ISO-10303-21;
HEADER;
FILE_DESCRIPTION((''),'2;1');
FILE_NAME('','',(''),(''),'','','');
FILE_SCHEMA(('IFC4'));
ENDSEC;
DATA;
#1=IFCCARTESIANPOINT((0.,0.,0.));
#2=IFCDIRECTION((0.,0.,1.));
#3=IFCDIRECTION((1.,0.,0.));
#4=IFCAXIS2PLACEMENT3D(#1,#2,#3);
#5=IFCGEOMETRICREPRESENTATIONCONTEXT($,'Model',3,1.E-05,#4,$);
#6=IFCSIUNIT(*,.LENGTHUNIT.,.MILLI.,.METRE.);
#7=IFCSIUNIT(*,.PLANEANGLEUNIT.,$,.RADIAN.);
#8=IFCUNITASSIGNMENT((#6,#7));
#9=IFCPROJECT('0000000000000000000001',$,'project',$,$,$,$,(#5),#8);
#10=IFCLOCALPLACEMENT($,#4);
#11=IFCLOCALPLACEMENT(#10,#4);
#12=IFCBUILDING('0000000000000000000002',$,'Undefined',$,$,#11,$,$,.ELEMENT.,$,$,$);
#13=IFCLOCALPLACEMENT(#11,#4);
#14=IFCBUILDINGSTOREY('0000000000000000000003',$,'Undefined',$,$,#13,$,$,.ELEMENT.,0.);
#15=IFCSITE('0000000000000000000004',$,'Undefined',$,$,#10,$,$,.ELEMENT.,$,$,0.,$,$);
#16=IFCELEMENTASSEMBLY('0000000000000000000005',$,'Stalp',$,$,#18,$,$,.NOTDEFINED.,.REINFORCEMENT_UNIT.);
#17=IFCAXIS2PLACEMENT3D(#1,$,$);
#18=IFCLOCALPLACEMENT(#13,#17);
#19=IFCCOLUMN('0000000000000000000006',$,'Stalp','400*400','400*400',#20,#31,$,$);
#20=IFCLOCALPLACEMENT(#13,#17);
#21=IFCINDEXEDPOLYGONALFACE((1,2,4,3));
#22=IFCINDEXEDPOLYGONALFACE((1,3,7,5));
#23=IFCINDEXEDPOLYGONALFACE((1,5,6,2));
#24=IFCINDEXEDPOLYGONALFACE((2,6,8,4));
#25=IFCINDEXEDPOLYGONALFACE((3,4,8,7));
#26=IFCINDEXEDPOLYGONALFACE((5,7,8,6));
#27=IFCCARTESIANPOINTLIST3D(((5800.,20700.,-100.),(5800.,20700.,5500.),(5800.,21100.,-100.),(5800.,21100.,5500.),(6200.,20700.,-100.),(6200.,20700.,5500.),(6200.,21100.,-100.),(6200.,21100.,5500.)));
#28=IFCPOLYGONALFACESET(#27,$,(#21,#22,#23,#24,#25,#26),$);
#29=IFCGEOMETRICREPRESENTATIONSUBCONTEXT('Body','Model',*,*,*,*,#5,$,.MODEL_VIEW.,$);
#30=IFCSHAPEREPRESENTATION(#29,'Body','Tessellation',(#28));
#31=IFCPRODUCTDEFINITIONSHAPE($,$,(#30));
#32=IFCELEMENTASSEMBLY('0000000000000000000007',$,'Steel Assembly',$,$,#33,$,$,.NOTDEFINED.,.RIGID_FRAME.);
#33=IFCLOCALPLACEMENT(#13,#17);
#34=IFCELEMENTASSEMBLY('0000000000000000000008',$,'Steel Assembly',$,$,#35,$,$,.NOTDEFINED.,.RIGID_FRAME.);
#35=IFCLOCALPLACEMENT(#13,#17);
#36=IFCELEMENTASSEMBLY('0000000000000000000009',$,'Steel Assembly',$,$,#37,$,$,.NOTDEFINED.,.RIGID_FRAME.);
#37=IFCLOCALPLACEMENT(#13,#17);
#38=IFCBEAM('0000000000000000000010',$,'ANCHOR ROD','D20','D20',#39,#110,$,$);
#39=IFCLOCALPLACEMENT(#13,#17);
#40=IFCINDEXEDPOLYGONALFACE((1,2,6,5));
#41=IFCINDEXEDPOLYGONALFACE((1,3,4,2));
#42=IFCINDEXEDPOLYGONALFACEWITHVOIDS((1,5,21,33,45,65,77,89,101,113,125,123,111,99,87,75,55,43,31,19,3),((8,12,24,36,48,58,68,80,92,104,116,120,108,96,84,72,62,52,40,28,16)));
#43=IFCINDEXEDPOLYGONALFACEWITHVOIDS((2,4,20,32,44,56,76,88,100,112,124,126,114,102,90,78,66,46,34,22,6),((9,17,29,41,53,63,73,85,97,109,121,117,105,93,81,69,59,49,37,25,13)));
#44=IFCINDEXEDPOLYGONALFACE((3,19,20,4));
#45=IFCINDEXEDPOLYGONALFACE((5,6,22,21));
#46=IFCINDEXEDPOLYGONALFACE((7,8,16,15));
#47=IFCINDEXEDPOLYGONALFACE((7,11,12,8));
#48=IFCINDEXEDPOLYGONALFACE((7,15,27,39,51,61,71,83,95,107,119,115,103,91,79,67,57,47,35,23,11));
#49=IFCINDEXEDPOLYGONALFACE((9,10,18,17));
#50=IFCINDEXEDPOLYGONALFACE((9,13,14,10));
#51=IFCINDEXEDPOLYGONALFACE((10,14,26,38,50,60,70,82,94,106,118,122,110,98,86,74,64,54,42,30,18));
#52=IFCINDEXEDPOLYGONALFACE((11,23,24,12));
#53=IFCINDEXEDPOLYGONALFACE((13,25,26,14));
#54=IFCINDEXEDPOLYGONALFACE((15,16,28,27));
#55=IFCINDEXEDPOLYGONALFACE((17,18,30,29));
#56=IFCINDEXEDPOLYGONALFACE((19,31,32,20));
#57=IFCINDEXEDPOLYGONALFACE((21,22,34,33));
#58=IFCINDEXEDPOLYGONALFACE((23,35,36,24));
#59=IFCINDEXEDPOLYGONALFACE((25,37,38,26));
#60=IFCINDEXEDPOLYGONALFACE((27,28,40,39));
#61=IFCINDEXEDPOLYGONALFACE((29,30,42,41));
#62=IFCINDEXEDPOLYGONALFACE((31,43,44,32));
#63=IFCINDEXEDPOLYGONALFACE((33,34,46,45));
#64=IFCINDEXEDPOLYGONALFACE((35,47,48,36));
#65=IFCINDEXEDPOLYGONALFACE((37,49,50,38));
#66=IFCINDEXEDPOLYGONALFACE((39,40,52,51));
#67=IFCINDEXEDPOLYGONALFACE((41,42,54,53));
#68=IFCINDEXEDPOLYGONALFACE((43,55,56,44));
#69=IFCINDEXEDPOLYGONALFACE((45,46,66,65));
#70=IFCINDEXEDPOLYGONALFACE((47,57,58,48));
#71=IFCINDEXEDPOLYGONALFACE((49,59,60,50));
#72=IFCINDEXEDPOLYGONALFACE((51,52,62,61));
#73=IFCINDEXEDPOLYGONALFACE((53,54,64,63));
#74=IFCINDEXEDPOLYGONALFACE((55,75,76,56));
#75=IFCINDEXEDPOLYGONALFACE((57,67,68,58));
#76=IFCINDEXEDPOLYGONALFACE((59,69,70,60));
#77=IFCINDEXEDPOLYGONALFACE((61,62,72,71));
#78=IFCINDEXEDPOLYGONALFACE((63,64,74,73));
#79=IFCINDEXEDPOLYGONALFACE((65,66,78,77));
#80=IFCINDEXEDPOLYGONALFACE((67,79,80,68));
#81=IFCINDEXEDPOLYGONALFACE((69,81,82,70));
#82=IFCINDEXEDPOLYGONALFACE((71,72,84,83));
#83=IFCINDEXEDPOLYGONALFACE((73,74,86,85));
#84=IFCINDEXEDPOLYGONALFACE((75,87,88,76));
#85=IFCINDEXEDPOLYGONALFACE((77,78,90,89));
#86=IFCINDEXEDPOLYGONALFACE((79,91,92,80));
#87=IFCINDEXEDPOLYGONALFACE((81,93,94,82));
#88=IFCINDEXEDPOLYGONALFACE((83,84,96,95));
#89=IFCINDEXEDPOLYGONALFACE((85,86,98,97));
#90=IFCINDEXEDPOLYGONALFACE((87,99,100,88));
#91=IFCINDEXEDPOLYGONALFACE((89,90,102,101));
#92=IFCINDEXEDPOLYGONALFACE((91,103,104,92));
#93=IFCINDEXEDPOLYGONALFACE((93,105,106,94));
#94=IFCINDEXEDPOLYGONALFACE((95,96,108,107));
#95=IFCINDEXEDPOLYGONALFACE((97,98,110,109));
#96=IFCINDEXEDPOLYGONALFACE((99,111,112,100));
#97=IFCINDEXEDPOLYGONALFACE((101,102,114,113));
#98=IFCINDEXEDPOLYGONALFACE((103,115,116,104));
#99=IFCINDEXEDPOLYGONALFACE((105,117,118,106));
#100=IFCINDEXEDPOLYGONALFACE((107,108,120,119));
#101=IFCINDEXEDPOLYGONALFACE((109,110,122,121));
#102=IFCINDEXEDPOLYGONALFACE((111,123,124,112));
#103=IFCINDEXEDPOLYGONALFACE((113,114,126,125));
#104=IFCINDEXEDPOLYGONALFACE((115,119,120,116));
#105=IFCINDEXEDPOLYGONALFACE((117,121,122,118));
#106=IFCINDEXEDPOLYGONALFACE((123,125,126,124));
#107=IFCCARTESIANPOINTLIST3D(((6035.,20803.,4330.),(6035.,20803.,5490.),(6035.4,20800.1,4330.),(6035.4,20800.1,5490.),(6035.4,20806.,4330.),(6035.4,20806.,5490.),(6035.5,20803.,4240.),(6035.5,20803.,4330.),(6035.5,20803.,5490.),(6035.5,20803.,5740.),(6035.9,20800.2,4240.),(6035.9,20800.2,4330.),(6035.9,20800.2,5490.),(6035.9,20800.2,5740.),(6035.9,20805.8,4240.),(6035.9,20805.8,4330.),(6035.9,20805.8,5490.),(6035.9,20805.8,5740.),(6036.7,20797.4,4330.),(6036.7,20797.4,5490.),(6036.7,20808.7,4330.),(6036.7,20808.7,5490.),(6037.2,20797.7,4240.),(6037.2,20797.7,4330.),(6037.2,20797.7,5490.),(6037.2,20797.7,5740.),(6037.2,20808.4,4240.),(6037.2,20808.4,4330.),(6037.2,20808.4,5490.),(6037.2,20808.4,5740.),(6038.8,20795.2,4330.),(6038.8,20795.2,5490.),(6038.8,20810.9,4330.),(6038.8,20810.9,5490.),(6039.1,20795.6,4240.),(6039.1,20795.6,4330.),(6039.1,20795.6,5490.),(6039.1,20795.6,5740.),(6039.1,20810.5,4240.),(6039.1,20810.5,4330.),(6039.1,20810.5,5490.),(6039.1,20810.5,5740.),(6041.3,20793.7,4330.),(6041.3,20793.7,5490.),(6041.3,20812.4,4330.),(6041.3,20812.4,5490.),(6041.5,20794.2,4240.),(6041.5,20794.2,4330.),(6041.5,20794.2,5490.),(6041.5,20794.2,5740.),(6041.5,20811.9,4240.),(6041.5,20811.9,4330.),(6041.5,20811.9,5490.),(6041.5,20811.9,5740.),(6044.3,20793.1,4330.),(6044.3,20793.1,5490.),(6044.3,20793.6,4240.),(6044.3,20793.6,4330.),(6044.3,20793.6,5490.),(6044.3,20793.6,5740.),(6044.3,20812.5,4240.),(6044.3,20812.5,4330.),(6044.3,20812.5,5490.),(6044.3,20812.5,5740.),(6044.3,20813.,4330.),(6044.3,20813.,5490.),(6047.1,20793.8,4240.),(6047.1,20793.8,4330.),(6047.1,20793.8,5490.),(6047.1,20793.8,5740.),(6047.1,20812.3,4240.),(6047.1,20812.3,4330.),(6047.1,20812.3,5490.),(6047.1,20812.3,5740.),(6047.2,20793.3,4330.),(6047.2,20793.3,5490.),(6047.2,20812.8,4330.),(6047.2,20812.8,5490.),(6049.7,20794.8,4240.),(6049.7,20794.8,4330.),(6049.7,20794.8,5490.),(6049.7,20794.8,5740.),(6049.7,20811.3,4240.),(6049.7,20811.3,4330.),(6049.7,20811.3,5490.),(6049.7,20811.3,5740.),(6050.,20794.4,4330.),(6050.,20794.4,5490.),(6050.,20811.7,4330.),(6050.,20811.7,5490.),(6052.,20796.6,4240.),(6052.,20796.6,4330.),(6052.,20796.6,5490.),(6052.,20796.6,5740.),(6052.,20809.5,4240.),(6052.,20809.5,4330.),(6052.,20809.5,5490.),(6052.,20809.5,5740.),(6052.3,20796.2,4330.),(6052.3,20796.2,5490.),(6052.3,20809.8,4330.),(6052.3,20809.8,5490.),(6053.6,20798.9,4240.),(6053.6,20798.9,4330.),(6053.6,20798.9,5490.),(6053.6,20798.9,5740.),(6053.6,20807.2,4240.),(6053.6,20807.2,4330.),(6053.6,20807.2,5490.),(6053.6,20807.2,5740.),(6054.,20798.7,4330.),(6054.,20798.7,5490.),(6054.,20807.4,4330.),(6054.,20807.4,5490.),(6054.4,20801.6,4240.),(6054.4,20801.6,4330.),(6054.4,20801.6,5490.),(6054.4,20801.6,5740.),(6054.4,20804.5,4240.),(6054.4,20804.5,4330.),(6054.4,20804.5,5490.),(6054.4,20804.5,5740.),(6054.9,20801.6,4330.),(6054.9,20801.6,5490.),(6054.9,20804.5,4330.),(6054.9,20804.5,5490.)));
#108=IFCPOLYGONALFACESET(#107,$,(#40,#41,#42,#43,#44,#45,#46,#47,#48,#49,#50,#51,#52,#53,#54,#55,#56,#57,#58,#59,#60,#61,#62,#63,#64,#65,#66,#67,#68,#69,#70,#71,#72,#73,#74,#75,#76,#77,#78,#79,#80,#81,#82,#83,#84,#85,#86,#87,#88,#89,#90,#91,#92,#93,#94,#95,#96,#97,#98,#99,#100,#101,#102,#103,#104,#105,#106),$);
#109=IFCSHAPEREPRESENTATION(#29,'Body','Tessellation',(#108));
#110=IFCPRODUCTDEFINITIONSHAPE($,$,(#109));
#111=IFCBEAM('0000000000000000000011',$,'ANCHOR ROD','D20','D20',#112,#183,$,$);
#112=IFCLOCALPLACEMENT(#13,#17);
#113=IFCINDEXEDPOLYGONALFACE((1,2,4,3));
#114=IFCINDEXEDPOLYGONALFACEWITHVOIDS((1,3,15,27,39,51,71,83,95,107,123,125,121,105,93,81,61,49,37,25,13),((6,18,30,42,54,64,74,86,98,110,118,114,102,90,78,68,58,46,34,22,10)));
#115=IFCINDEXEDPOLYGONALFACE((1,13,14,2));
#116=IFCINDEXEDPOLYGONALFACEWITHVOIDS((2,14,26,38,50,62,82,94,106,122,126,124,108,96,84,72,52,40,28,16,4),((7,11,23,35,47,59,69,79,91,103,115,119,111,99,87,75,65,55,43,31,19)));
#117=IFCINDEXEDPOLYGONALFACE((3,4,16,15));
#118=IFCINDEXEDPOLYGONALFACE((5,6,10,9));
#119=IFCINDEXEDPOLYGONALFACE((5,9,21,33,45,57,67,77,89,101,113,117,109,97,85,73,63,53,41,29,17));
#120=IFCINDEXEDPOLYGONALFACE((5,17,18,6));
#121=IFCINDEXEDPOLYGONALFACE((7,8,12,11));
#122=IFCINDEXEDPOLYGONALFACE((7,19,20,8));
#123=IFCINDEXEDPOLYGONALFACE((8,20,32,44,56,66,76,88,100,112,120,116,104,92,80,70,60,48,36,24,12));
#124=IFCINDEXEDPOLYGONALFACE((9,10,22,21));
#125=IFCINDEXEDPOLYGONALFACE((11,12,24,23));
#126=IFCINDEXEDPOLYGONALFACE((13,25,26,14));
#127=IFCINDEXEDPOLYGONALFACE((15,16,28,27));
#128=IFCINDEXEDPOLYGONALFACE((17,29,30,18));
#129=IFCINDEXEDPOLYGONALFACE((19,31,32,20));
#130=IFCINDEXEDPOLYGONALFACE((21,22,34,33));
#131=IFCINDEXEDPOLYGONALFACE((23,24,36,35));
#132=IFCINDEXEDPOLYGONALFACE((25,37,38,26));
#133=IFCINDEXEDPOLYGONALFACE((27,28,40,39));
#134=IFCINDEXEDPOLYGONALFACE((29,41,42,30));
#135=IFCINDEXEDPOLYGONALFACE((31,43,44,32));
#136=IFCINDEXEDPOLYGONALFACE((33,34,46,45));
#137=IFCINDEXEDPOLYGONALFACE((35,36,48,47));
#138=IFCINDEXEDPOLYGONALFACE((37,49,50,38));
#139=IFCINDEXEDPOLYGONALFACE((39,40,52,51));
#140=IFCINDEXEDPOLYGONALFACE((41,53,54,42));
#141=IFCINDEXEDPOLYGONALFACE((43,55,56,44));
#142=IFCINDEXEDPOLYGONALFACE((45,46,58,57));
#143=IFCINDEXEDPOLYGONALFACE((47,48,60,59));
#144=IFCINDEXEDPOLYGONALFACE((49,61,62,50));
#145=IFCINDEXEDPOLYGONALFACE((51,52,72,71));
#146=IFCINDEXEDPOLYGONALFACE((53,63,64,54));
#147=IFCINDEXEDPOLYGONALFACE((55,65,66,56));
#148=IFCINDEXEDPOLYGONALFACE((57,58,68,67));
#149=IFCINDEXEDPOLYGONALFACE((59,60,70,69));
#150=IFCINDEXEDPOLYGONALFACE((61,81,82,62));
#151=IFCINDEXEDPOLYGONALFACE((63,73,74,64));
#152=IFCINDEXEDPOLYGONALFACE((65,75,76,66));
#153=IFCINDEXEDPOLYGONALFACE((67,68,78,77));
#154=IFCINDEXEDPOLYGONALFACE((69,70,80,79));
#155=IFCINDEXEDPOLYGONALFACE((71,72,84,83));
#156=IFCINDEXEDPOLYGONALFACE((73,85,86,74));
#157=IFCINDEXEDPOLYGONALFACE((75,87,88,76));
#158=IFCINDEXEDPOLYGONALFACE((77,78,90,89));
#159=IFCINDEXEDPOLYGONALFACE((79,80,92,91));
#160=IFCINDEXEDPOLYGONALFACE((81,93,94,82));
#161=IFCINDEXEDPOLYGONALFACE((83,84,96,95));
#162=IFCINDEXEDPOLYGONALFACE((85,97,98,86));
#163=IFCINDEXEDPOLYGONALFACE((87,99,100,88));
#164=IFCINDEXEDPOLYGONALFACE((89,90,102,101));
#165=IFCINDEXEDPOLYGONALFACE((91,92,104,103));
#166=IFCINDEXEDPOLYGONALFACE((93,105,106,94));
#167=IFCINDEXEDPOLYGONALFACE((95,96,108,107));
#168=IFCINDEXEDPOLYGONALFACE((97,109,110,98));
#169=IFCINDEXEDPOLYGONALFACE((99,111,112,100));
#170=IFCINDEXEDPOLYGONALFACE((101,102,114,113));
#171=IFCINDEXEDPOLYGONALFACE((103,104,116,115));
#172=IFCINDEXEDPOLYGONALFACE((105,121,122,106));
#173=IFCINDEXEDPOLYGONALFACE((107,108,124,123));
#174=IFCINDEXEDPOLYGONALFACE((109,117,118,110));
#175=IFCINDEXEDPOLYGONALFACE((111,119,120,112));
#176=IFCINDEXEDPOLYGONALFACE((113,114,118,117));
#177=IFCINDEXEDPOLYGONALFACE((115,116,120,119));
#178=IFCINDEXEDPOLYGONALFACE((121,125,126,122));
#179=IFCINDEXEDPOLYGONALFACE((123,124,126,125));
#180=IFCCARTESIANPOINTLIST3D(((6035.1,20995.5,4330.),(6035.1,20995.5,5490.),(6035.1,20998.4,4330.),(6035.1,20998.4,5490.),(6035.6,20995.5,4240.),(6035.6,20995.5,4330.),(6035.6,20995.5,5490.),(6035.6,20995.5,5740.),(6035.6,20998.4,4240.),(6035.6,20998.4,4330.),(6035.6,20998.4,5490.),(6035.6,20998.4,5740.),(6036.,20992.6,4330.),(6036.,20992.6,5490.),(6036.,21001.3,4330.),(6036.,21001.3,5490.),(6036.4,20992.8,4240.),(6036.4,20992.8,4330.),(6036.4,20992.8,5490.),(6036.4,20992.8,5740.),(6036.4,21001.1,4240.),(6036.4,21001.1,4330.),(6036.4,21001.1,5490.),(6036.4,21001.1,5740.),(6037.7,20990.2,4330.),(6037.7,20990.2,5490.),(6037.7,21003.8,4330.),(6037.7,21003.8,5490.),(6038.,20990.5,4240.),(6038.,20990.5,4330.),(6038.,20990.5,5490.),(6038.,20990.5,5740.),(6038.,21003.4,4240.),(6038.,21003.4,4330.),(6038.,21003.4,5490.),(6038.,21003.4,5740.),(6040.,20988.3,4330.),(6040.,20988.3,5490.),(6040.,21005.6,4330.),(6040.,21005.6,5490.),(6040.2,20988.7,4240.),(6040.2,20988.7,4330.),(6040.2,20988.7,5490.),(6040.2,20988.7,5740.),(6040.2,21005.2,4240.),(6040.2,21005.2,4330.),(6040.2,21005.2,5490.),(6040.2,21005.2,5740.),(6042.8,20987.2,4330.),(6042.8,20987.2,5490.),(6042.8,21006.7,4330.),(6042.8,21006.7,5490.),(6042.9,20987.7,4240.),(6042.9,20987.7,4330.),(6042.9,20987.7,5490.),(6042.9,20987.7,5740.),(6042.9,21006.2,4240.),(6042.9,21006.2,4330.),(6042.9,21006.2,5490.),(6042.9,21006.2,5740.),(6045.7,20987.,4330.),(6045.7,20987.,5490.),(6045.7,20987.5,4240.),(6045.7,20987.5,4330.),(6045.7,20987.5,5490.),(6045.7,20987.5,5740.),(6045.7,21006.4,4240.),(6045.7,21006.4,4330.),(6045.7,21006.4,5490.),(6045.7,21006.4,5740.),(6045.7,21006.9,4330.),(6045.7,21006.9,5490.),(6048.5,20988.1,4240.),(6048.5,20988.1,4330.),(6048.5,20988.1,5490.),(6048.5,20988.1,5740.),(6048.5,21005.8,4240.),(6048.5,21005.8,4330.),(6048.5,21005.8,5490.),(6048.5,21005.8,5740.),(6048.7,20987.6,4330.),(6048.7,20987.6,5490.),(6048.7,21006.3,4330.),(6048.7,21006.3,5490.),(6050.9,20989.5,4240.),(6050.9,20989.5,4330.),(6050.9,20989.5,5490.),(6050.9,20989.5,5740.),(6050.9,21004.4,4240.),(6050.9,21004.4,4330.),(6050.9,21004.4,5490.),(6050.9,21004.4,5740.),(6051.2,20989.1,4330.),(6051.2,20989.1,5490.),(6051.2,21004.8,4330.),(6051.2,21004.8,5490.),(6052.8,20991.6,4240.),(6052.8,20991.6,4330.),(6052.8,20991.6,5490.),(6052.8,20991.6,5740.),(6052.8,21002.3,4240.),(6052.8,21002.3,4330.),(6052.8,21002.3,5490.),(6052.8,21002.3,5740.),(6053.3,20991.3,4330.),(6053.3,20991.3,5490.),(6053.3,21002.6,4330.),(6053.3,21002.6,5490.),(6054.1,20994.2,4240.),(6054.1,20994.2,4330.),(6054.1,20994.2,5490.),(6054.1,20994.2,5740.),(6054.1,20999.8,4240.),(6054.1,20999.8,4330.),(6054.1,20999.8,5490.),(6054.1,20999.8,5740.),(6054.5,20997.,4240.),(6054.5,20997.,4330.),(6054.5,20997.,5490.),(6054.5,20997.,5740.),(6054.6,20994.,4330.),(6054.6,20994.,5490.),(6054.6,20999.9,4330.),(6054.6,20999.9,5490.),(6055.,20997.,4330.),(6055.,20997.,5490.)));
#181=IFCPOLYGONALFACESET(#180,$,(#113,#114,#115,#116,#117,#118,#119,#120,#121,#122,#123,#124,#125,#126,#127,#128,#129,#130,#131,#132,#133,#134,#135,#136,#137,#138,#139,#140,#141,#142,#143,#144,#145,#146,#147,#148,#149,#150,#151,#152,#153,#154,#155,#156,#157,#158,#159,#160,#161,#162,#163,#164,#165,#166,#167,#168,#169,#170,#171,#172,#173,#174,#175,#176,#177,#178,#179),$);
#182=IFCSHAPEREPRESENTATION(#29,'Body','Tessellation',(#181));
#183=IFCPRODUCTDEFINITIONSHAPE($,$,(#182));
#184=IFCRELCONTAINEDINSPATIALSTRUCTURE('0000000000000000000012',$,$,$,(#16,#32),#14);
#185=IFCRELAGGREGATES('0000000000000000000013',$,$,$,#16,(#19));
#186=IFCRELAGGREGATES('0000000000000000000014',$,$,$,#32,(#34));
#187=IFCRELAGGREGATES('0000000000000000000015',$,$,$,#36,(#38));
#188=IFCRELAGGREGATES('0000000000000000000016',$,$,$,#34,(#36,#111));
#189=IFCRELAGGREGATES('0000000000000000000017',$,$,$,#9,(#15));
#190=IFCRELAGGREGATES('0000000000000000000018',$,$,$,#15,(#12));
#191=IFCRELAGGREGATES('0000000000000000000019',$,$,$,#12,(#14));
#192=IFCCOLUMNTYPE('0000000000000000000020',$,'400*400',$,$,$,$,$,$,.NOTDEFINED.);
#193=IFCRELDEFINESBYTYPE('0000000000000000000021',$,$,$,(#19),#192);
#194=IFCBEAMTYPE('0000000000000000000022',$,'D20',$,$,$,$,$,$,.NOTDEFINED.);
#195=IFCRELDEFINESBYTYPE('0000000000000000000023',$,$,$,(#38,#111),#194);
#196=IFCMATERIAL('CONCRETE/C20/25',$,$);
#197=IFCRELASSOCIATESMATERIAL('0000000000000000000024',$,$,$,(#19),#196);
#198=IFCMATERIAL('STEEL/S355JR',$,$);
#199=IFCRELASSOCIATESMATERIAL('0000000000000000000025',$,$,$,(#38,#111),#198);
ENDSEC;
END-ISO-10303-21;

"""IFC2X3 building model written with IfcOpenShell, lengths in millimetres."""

from ifc_helpers import new_model, si_unit, frame, origin_with_axes, origin_2d_with_axis, place, context, subcontext, project, spatial, rectangle, circle, extrude, boolean, material, type_object, element, aggregate, save


model = new_model("IFC2X3")

# Units and contexts
model_context = context("Model", 3, precision=1e-05, world=origin_with_axes())
body_context = subcontext(model_context, "Body", "Model", "MODEL_VIEW")
ifc_project = project(units=[si_unit("LENGTHUNIT", "METRE", prefix="MILLI"), si_unit("PLANEANGLEUNIT", "RADIAN")], contexts=[model_context])

# Site, building, storey
site_placement = place(None, origin_with_axes())
site = spatial("IfcSite", under=ifc_project, at=site_placement, Name="Undefined", CompositionType="ELEMENT", RefElevation=0.0)
building_placement = place(site_placement, origin_with_axes())
building = spatial("IfcBuilding", under=site, at=building_placement, Name="Undefined", CompositionType="ELEMENT")
storey_placement = place(building_placement, origin_with_axes())
storey = spatial("IfcBuildingStorey", under=building, at=storey_placement, Name="Undefined", CompositionType="ELEMENT", Elevation=0.0)

# Element assembly, column
assembly_1_placement = place(storey_placement, origin_with_axes())
assembly_1 = element("IfcElementAssembly", 1, at=assembly_1_placement, inside=storey, Name="Stalp", AssemblyPlace="NOTDEFINED", PredefinedType="REINFORCEMENT_UNIT")
ifc_material_1 = material(Name="CONCRETE/C20/25")
column_type = type_object("IfcColumnType", Name="400*400", PredefinedType="NOTDEFINED")
column_placement = place(assembly_1_placement, frame((6000.0, 20900.0, -100.0), z_axis=(0.0, 0.0, 1.0), x_axis=(0.0, 1.0, 0.0)))
column = element("IfcColumn", 2, at=column_placement, type_object=column_type, material=ifc_material_1, Name="Stalp", Description="400*400", ObjectType="400*400", context=body_context, shape_type="SweptSolid", body=[
    extrude(rectangle(XDim=400.0, YDim=400.0, at=origin_2d_with_axis()), frame((0.0, 0.0, 5600.0), z_axis=(0.0, 0.0, -1.0), x_axis=(0.0, 1.0, 0.0)), (0.0, 0.0, 1.0), 5600.0),
])
aggregate(assembly_1, [column])

# Element assemblies, beams
assembly_2_placement = place(storey_placement, origin_with_axes())
assembly_2 = element("IfcElementAssembly", 3, at=assembly_2_placement, inside=storey, Name="Steel Assembly", AssemblyPlace="NOTDEFINED", PredefinedType="RIGID_FRAME")
assembly_3_placement = place(assembly_2_placement, origin_with_axes())
assembly_3 = element("IfcElementAssembly", 4, at=assembly_3_placement, Name="Steel Assembly", AssemblyPlace="NOTDEFINED", PredefinedType="RIGID_FRAME")
assembly_4_placement = place(assembly_3_placement, origin_with_axes())
assembly_4 = element("IfcElementAssembly", 5, at=assembly_4_placement, Name="Steel Assembly", AssemblyPlace="NOTDEFINED", PredefinedType="RIGID_FRAME")
ifc_material_2 = material(Name="STEEL/S355JR")
beam_type = type_object("IfcBeamType", Name="D20", PredefinedType="NOTDEFINED")
beam_1_placement = place(assembly_4_placement, frame((6045.0, 20803.0, 5490.0), z_axis=(0.0, -1.0, 0.0), x_axis=(0.0, 0.0, -1.0)))
beam_1 = element("IfcBeam", 6, at=beam_1_placement, type_object=beam_type, material=ifc_material_2, Name="ANCHOR ROD", Description="D20", ObjectType="D20", context=body_context, shape_type="CSG", body=[
    boolean("UNION", boolean("UNION", extrude(circle(Radius=10.0, at=origin_2d_with_axis()), frame((1160.0, 0.0, 0.0), z_axis=(-1.0, 0.0, 0.0), x_axis=(0.0, -1.0, 0.0)), (0.0, 0.0, 1.0), 1160.0), extrude(circle(Radius=9.5, at=origin_2d_with_axis()), frame((1250.0, 0.0, 0.0), z_axis=(-1.0, 0.0, 0.0), x_axis=(0.0, -1.0, 0.0)), (0.0, 0.0, 1.0), 90.0)), extrude(circle(Radius=9.5, at=origin_2d_with_axis()), frame((0.0, 0.0, 0.0), z_axis=(-1.0, 0.0, 0.0), x_axis=(0.0, -1.0, 0.0)), (0.0, 0.0, 1.0), 250.0)),
])
beam_2_placement = place(assembly_3_placement, frame((6045.0, 20997.0, 5490.0), z_axis=(0.0, 1.0, 0.0), x_axis=(0.0, 0.0, -1.0)))
beam_2 = element("IfcBeam", 7, at=beam_2_placement, type_object=beam_type, material=ifc_material_2, Name="ANCHOR ROD", Description="D20", ObjectType="D20", context=body_context, shape_type="CSG", body=[
    boolean("UNION", boolean("UNION", extrude(circle(Radius=10.0, at=origin_2d_with_axis()), frame((1160.0, 0.0, 0.0), z_axis=(-1.0, 0.0, 0.0), x_axis=(0.0, -1.0, 0.0)), (0.0, 0.0, 1.0), 1160.0), extrude(circle(Radius=9.5, at=origin_2d_with_axis()), frame((1250.0, 0.0, 0.0), z_axis=(-1.0, 0.0, 0.0), x_axis=(0.0, -1.0, 0.0)), (0.0, 0.0, 1.0), 90.0)), extrude(circle(Radius=9.5, at=origin_2d_with_axis()), frame((0.0, 0.0, 0.0), z_axis=(-1.0, 0.0, 0.0), x_axis=(0.0, -1.0, 0.0)), (0.0, 0.0, 1.0), 250.0)),
])

aggregate(assembly_2, [assembly_3])

aggregate(assembly_4, [beam_1])
aggregate(assembly_3, [assembly_4, beam_2])

save(model, "model.ifc")
